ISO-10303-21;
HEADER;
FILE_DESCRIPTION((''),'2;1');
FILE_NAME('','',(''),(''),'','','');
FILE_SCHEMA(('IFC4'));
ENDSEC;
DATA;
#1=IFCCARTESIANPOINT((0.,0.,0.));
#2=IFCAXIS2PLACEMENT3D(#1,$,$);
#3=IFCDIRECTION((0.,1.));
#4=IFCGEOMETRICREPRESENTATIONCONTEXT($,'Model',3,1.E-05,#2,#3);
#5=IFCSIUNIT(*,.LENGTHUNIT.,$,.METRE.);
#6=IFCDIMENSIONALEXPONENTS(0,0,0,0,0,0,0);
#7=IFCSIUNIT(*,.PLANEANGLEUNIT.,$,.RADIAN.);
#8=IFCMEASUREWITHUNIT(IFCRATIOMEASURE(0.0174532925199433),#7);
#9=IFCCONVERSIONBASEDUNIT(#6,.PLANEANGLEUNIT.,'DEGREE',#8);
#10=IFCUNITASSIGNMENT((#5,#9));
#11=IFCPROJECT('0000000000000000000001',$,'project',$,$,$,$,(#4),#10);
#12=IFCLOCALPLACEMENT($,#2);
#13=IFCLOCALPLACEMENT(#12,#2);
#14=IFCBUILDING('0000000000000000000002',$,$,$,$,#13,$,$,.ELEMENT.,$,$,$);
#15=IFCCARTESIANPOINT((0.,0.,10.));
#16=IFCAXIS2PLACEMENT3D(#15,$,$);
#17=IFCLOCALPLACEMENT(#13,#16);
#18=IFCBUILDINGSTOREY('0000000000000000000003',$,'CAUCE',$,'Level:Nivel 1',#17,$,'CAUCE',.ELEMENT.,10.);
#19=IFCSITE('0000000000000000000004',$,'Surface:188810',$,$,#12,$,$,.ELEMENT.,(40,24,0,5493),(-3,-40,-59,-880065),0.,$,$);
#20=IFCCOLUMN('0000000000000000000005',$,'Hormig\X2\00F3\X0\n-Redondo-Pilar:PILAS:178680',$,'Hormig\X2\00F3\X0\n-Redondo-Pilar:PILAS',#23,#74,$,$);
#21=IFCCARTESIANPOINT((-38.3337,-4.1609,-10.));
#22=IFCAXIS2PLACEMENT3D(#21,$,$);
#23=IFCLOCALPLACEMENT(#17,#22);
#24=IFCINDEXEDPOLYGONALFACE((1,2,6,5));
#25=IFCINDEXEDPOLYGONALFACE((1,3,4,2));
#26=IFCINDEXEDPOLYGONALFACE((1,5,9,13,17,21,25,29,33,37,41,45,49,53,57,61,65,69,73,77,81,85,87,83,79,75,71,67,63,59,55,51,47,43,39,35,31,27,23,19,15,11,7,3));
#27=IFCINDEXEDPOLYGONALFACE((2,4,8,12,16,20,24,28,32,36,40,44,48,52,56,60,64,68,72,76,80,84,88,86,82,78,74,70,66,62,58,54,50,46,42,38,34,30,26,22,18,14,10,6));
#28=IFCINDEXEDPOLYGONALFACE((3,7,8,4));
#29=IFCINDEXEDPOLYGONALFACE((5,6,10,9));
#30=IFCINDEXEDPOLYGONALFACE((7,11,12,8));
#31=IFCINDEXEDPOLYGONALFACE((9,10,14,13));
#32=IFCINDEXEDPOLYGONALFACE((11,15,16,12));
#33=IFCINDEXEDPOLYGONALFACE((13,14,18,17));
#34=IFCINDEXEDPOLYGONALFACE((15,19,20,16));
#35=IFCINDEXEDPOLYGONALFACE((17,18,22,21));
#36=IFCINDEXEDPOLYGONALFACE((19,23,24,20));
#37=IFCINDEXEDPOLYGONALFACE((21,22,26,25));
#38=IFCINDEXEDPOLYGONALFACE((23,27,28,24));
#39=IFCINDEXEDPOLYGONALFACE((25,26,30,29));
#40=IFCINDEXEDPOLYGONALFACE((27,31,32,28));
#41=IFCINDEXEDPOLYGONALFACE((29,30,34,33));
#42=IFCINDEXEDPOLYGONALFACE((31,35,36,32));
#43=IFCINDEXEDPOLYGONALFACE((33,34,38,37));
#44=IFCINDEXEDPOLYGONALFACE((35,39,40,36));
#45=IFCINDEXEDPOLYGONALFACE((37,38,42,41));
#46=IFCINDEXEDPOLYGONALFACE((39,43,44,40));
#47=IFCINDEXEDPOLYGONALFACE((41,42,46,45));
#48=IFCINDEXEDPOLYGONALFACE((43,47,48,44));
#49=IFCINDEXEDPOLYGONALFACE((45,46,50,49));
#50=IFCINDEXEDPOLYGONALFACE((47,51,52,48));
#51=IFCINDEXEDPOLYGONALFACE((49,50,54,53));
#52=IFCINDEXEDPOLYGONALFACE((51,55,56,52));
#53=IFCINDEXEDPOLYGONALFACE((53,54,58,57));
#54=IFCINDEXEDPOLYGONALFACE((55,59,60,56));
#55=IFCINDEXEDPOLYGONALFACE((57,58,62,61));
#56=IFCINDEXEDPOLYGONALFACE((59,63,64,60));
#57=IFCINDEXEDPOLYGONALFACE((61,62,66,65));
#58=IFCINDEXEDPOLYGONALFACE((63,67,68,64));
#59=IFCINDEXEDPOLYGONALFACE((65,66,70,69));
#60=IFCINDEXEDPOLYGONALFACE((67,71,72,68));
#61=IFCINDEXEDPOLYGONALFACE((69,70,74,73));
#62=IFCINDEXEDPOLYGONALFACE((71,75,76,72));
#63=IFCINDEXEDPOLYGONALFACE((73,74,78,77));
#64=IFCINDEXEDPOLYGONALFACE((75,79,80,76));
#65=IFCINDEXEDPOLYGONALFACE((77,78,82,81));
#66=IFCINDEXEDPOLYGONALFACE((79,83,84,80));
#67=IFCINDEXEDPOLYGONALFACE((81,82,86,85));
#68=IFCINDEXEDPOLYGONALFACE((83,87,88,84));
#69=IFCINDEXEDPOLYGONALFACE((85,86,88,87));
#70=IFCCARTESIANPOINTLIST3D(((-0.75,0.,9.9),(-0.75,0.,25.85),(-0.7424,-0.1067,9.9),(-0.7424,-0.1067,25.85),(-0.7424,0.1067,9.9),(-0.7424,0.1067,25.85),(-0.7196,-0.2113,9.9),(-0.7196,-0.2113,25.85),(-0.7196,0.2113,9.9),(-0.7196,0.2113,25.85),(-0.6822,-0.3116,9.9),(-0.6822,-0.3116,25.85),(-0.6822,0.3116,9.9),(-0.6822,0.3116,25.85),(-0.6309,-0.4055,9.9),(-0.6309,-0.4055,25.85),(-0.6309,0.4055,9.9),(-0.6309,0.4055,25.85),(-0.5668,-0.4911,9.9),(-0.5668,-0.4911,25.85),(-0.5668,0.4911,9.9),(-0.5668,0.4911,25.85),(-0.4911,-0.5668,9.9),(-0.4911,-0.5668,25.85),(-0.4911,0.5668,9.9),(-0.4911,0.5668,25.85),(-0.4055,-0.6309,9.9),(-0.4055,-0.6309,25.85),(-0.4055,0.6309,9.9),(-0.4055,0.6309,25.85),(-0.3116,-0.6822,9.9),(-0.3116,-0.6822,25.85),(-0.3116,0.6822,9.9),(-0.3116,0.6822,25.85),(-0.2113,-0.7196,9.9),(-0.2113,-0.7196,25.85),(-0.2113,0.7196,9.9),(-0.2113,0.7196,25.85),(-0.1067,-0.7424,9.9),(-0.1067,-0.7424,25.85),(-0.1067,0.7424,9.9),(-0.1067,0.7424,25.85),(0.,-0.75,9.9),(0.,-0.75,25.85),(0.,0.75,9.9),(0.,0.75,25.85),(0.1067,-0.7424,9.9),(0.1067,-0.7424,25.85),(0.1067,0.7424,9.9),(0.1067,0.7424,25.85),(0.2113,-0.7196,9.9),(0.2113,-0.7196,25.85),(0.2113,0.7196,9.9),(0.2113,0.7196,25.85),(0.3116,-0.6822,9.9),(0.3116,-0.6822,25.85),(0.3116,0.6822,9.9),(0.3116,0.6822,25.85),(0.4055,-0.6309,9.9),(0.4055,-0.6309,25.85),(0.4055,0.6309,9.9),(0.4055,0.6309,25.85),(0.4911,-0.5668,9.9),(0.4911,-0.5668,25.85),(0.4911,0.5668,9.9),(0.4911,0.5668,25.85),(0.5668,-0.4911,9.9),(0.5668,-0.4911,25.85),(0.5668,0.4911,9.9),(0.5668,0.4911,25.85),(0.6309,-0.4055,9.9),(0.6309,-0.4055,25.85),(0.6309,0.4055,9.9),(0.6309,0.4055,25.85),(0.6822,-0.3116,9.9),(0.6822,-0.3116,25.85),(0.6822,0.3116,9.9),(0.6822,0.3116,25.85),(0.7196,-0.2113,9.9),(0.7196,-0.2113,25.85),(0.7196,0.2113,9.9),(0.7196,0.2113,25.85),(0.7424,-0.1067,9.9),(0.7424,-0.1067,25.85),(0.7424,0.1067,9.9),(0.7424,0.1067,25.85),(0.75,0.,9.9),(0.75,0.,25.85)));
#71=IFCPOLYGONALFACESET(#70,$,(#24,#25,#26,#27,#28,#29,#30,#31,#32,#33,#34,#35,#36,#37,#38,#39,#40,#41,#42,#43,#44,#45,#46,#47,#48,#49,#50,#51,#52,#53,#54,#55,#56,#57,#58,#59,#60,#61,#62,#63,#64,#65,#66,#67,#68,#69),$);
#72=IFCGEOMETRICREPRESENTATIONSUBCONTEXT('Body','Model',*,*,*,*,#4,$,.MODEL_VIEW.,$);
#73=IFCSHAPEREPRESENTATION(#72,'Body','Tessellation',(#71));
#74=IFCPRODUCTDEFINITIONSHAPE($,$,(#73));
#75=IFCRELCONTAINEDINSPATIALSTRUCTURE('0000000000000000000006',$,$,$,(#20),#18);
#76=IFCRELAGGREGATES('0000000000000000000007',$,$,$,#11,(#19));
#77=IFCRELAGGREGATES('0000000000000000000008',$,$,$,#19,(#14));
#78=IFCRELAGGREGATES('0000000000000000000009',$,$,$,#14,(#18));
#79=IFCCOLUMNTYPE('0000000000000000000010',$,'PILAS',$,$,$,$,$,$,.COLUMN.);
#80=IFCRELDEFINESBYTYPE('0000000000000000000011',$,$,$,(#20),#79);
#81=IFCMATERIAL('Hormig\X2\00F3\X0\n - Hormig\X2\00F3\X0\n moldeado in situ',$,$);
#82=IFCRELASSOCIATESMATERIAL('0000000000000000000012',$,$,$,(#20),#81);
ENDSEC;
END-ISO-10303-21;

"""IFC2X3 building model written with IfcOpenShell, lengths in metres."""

from ifc_helpers import new_model, entity, si_unit, converted_unit, direction, frame, frame_2d, origin, place, context, subcontext, project, spatial, circle, extrude, source, transform, mapped, material, type_object, type_shapes, element, save


model = new_model("IFC2X3")

# Units and contexts
model_context = context("Model", 3, precision=1e-05, world=origin(), true_north=direction((0.0, 1.0)))
body_context = subcontext(model_context, "Body", "Model", "MODEL_VIEW")
ifc_project = project(units=[si_unit("LENGTHUNIT", "METRE"), converted_unit("PLANEANGLEUNIT", "DEGREE", entity("IfcRatioMeasure", 0.0174532925199433), si_unit("PLANEANGLEUNIT", "RADIAN"), dimensions=[0, 0, 0, 0, 0, 0, 0])], contexts=[model_context])

# Site, building, storey
site_placement = place(None, origin())
site = spatial("IfcSite", under=ifc_project, at=site_placement, Name="Surface:188810", CompositionType="ELEMENT", RefLatitude=(40, 24, 0, 5493), RefLongitude=(-3, -40, -59, -880065), RefElevation=0.0)
building_placement = place(site_placement, origin())
building = spatial("IfcBuilding", under=site, at=building_placement, CompositionType="ELEMENT")
storey_placement = place(building_placement, frame((0.0, 0.0, 10.0)))
storey = spatial("IfcBuildingStorey", under=building, at=storey_placement, Name="CAUCE", ObjectType="Level:Nivel 1", LongName="CAUCE", CompositionType="ELEMENT", Elevation=10.0)

# Column
ifc_material_1 = material(Name="Hormigón - Hormigón moldeado in situ")
column_type_1 = type_object("IfcColumnType", Name="PILAS", PredefinedType="COLUMN")
shared_shape_1 = source(origin(), body_context, "Body", "SweptSolid", [
    extrude(circle(Radius=0.75, at=frame_2d((0.0, 0.0), x_axis=(1.0, 0.0))), frame((0.0, 0.0, 9.9), z_axis=(0.0, 0.0, 1.0), x_axis=(-1.0, 0.0, 0.0)), (0.0, 0.0, 1.0), 15.95),
])
type_shapes(column_type_1, [shared_shape_1])
column_1_placement = place(storey_placement, frame((-38.3337, -4.1609, -10.0)))
element("IfcColumn", 1, at=column_1_placement, inside=storey, type_object=column_type_1, material=ifc_material_1, Name="Hormigón-Redondo-Pilar:PILAS:178680", ObjectType="Hormigón-Redondo-Pilar:PILAS", context=body_context, shape_type="MappedRepresentation", body=[
    mapped(shared_shape_1, transform((0.0, 0.0, 0.0), scale=1.0)),
])

save(model, "model.ifc")
